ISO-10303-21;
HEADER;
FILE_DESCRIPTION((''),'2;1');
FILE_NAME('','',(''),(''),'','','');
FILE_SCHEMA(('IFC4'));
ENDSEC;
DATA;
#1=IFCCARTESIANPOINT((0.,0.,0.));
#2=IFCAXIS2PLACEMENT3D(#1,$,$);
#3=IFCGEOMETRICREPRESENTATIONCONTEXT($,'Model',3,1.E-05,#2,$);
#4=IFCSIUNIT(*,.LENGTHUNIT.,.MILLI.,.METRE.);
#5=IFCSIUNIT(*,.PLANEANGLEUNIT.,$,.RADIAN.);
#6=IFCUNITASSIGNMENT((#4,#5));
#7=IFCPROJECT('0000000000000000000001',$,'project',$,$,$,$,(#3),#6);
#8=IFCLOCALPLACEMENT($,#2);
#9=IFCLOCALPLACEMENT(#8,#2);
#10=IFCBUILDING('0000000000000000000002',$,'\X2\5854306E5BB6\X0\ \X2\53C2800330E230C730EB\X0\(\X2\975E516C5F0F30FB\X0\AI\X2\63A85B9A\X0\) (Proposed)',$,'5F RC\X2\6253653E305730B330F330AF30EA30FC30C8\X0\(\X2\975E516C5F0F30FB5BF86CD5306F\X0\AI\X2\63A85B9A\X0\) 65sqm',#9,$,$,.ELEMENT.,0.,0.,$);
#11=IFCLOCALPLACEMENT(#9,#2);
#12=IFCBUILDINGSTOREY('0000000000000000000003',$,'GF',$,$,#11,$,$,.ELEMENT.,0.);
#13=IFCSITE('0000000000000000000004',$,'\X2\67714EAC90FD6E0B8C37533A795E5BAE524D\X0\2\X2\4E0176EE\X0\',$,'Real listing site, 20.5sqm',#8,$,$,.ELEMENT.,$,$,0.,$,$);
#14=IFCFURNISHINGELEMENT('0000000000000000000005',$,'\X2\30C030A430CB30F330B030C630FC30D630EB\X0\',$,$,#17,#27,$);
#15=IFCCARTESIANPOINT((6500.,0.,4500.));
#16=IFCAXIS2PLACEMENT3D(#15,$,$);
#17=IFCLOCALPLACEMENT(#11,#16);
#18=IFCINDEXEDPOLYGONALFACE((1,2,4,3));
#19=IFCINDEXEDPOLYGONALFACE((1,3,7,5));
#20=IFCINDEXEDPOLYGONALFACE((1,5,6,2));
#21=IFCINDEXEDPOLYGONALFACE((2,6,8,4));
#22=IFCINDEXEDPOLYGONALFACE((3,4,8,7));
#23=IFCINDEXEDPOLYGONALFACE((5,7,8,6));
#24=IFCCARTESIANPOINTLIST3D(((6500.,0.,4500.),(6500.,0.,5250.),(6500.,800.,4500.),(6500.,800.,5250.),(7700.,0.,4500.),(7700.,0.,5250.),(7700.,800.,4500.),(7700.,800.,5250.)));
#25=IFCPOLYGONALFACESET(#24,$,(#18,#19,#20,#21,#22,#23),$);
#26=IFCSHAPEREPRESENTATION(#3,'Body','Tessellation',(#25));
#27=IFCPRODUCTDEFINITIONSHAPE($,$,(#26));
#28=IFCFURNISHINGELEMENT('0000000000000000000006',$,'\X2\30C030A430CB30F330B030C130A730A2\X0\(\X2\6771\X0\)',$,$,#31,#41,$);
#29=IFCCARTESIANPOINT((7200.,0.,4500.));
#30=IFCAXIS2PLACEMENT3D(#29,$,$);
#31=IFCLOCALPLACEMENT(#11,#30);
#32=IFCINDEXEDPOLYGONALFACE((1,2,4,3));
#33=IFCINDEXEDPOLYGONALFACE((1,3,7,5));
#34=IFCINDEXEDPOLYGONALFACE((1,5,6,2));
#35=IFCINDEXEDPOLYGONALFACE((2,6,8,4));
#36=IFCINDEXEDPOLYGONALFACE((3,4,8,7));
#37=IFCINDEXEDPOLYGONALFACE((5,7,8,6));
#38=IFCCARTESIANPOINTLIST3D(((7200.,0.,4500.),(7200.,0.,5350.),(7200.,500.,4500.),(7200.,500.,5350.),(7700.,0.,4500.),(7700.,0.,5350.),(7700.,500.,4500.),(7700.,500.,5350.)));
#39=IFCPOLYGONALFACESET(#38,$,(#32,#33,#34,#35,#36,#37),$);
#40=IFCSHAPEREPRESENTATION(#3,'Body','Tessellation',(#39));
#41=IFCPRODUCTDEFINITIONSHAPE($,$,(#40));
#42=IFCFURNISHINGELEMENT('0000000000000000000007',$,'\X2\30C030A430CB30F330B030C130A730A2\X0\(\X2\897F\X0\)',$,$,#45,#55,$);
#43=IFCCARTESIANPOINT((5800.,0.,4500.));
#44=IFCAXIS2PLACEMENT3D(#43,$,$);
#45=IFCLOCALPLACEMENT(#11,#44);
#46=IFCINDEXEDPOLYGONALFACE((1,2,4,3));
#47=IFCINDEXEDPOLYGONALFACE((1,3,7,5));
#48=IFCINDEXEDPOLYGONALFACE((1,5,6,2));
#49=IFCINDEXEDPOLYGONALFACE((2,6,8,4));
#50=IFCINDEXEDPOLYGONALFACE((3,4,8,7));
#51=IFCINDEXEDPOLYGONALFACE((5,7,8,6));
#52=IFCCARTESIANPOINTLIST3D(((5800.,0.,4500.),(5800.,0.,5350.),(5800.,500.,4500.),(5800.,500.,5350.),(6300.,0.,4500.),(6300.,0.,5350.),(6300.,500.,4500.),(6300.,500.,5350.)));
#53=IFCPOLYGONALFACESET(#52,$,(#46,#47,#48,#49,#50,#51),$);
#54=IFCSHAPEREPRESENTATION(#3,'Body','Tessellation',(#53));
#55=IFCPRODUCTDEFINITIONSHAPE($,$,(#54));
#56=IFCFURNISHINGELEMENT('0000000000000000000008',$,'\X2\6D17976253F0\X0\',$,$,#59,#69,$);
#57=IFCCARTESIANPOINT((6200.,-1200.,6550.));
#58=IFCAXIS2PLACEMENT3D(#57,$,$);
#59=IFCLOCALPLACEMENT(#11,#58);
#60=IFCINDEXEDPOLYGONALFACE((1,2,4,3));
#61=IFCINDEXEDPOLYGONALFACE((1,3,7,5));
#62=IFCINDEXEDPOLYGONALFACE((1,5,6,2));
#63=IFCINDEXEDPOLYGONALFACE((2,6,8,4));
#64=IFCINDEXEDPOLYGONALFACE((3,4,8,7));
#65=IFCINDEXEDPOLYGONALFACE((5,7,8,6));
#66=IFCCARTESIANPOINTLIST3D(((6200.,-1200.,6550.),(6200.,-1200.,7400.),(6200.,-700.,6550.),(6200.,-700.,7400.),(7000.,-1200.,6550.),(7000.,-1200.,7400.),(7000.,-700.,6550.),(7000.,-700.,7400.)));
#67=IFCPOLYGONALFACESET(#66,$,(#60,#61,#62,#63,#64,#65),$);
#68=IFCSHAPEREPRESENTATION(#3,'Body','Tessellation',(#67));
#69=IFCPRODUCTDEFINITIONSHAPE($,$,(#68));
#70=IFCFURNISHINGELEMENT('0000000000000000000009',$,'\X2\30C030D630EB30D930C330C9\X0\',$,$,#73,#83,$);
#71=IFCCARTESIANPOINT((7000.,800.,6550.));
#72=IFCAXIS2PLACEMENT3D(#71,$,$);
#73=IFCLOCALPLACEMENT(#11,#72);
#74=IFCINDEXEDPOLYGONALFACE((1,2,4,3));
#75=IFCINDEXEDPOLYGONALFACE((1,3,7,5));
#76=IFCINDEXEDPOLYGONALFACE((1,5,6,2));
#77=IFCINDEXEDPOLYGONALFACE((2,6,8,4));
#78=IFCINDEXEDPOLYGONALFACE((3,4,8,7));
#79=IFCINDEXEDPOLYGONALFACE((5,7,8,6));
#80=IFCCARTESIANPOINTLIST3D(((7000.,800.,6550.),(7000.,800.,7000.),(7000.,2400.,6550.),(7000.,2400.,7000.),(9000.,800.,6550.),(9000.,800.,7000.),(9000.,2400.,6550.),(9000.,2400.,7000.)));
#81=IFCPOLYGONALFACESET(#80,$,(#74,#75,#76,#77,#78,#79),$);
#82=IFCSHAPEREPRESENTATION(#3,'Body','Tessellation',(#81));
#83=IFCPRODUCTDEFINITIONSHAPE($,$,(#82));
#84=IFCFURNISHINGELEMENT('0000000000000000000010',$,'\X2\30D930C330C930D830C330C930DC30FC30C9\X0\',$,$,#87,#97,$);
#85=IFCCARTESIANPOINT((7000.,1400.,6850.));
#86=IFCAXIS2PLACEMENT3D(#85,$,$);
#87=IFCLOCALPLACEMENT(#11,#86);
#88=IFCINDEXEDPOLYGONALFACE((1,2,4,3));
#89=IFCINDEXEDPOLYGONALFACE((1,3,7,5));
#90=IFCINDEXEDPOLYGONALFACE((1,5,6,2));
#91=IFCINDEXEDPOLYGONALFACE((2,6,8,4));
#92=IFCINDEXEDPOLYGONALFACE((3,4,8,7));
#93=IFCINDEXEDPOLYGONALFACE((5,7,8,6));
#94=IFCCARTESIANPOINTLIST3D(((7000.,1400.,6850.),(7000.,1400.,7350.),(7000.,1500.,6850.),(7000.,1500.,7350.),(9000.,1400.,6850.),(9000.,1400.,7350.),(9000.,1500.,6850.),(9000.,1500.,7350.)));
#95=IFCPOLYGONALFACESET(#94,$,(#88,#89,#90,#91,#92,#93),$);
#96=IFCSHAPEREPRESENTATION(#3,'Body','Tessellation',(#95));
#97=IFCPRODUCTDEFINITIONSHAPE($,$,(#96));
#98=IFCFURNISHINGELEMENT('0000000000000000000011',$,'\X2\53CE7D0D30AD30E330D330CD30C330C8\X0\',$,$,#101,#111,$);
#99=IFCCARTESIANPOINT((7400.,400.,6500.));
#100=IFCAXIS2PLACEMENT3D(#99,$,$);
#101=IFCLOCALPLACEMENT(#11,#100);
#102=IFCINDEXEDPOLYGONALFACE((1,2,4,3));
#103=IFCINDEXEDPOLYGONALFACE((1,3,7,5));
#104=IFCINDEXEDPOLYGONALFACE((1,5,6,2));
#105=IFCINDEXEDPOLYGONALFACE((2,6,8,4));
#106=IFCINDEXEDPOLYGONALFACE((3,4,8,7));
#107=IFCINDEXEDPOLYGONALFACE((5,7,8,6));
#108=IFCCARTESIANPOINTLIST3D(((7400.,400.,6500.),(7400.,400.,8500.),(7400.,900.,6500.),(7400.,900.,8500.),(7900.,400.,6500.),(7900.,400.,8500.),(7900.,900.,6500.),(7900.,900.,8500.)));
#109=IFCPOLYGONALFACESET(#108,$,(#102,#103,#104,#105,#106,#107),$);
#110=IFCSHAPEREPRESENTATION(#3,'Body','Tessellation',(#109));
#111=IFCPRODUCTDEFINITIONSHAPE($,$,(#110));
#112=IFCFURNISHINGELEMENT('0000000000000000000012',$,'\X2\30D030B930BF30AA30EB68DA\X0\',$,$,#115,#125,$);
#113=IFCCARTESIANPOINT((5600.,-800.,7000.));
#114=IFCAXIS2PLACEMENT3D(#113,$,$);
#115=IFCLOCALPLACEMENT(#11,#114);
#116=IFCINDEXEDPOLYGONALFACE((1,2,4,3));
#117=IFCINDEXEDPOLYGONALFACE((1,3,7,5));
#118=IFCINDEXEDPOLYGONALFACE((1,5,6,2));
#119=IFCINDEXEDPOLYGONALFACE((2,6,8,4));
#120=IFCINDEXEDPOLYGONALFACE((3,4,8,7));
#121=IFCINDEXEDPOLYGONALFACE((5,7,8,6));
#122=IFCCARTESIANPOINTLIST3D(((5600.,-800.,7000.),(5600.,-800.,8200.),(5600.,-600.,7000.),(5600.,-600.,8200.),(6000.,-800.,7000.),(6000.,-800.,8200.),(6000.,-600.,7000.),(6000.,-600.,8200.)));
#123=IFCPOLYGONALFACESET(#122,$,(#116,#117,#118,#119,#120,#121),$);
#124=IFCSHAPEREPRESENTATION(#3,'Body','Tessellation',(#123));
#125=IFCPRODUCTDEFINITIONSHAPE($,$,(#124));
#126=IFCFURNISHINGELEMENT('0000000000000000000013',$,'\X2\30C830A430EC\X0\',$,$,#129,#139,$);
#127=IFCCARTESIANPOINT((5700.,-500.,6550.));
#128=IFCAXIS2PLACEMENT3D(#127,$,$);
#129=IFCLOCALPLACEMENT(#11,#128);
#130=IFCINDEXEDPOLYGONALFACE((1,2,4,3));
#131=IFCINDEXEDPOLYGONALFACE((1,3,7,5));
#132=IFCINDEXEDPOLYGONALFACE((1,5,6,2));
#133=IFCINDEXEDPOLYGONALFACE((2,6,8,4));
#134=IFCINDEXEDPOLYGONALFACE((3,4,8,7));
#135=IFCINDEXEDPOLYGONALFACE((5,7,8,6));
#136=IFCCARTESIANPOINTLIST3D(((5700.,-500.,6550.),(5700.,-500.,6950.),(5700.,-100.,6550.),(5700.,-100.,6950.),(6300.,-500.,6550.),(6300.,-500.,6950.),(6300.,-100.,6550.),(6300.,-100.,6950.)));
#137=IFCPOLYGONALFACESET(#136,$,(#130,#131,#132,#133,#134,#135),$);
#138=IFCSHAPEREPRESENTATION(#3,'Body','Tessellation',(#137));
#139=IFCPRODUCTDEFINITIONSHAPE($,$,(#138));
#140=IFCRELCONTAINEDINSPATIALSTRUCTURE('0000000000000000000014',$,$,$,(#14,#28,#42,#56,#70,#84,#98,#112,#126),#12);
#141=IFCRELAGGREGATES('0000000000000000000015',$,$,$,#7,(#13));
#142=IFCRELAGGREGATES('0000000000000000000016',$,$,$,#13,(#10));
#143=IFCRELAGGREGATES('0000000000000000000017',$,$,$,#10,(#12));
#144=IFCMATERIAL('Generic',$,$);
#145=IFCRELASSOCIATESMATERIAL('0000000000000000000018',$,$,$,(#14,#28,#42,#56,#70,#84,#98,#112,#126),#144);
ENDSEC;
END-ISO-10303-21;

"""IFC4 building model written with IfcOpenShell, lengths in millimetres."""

from ifc_helpers import new_model, si_unit, frame, frame_2d, origin, place, context, project, spatial, rectangle, extrude, material, element, save


model = new_model("IFC4")

# Units and contexts
model_context = context("Model", 3, precision=1e-05, world=origin())
ifc_project = project(units=[si_unit("LENGTHUNIT", "METRE", prefix="MILLI"), si_unit("PLANEANGLEUNIT", "RADIAN")], contexts=[model_context])

# Site, building, storey
site_placement = place(None, origin())
site = spatial("IfcSite", under=ifc_project, at=site_placement, Name="東京都渋谷区神宮前2丁目", ObjectType="Real listing site, 20.5sqm", CompositionType="ELEMENT", RefElevation=0.0)
building_placement = place(site_placement, origin())
building = spatial("IfcBuilding", under=site, at=building_placement, Name="塔の家 参考モデル(非公式・AI推定) (Proposed)", ObjectType="5F RC打放しコンクリート(非公式・寸法はAI推定) 65sqm", CompositionType="ELEMENT", ElevationOfRefHeight=0.0, ElevationOfTerrain=0.0)
storey_placement = place(building_placement, origin())
storey = spatial("IfcBuildingStorey", under=building, at=storey_placement, Name="GF", CompositionType="ELEMENT", Elevation=0.0)

# Shared definitions
ifc_material = material(Name="Generic")

# Furnishing elements
furnishing_1_placement = place(storey_placement, frame((6500.0, 0.0, 4500.0)))
element("IfcFurnishingElement", 1, at=furnishing_1_placement, inside=storey, material=ifc_material, Name="ダイニングテーブル", context=model_context, shape_type="SweptSolid", body=[
    extrude(rectangle(XDim=1200.0, YDim=800.0, at=frame_2d((600.0, 400.0))), frame((6500.0, 0.0, 4500.0)), (0.0, 0.0, 1.0), 750.0),
])
furnishing_2_placement = place(storey_placement, frame((7200.0, 0.0, 4500.0)))
element("IfcFurnishingElement", 2, at=furnishing_2_placement, inside=storey, material=ifc_material, Name="ダイニングチェア(東)", context=model_context, shape_type="SweptSolid", body=[
    extrude(rectangle(XDim=500.0, YDim=500.0, at=frame_2d((250.0, 250.0))), frame((7200.0, 0.0, 4500.0)), (0.0, 0.0, 1.0), 850.0),
])
furnishing_3_placement = place(storey_placement, frame((5800.0, 0.0, 4500.0)))
element("IfcFurnishingElement", 3, at=furnishing_3_placement, inside=storey, material=ifc_material, Name="ダイニングチェア(西)", context=model_context, shape_type="SweptSolid", body=[
    extrude(rectangle(XDim=500.0, YDim=500.0, at=frame_2d((250.0, 250.0))), frame((5800.0, 0.0, 4500.0)), (0.0, 0.0, 1.0), 850.0),
])
furnishing_4_placement = place(storey_placement, frame((6200.0, -1200.0, 6550.0)))
element("IfcFurnishingElement", 4, at=furnishing_4_placement, inside=storey, material=ifc_material, Name="洗面台", context=model_context, shape_type="SweptSolid", body=[
    extrude(rectangle(XDim=800.0, YDim=500.0, at=frame_2d((400.0, 250.0))), frame((6200.0, -1200.0, 6550.0)), (0.0, 0.0, 1.0), 850.0),
])
furnishing_5_placement = place(storey_placement, frame((7000.0, 800.0, 6550.0)))
element("IfcFurnishingElement", 5, at=furnishing_5_placement, inside=storey, material=ifc_material, Name="ダブルベッド", context=model_context, shape_type="SweptSolid", body=[
    extrude(rectangle(XDim=2000.0, YDim=1600.0, at=frame_2d((1000.0, 800.0))), frame((7000.0, 800.0, 6550.0)), (0.0, 0.0, 1.0), 450.0),
])
furnishing_6_placement = place(storey_placement, frame((7000.0, 1400.0, 6850.0)))
element("IfcFurnishingElement", 6, at=furnishing_6_placement, inside=storey, material=ifc_material, Name="ベッドヘッドボード", context=model_context, shape_type="SweptSolid", body=[
    extrude(rectangle(XDim=2000.0, YDim=100.0, at=frame_2d((1000.0, 50.0))), frame((7000.0, 1400.0, 6850.0)), (0.0, 0.0, 1.0), 500.0),
])
furnishing_7_placement = place(storey_placement, frame((7400.0, 400.0, 6500.0)))
element("IfcFurnishingElement", 7, at=furnishing_7_placement, inside=storey, material=ifc_material, Name="収納キャビネット", context=model_context, shape_type="SweptSolid", body=[
    extrude(rectangle(XDim=500.0, YDim=500.0, at=frame_2d((250.0, 250.0))), frame((7400.0, 400.0, 6500.0)), (0.0, 0.0, 1.0), 2000.0),
])
furnishing_8_placement = place(storey_placement, frame((5600.0, -800.0, 7000.0)))
element("IfcFurnishingElement", 8, at=furnishing_8_placement, inside=storey, material=ifc_material, Name="バスタオル棚", context=model_context, shape_type="SweptSolid", body=[
    extrude(rectangle(XDim=400.0, YDim=200.0, at=frame_2d((200.0, 100.0))), frame((5600.0, -800.0, 7000.0)), (0.0, 0.0, 1.0), 1200.0),
])
furnishing_9_placement = place(storey_placement, frame((5700.0, -500.0, 6550.0)))
element("IfcFurnishingElement", 9, at=furnishing_9_placement, inside=storey, material=ifc_material, Name="トイレ", context=model_context, shape_type="SweptSolid", body=[
    extrude(rectangle(XDim=600.0, YDim=400.0, at=frame_2d((300.0, 200.0))), frame((5700.0, -500.0, 6550.0)), (0.0, 0.0, 1.0), 400.0),
])

save(model, "model.ifc")
